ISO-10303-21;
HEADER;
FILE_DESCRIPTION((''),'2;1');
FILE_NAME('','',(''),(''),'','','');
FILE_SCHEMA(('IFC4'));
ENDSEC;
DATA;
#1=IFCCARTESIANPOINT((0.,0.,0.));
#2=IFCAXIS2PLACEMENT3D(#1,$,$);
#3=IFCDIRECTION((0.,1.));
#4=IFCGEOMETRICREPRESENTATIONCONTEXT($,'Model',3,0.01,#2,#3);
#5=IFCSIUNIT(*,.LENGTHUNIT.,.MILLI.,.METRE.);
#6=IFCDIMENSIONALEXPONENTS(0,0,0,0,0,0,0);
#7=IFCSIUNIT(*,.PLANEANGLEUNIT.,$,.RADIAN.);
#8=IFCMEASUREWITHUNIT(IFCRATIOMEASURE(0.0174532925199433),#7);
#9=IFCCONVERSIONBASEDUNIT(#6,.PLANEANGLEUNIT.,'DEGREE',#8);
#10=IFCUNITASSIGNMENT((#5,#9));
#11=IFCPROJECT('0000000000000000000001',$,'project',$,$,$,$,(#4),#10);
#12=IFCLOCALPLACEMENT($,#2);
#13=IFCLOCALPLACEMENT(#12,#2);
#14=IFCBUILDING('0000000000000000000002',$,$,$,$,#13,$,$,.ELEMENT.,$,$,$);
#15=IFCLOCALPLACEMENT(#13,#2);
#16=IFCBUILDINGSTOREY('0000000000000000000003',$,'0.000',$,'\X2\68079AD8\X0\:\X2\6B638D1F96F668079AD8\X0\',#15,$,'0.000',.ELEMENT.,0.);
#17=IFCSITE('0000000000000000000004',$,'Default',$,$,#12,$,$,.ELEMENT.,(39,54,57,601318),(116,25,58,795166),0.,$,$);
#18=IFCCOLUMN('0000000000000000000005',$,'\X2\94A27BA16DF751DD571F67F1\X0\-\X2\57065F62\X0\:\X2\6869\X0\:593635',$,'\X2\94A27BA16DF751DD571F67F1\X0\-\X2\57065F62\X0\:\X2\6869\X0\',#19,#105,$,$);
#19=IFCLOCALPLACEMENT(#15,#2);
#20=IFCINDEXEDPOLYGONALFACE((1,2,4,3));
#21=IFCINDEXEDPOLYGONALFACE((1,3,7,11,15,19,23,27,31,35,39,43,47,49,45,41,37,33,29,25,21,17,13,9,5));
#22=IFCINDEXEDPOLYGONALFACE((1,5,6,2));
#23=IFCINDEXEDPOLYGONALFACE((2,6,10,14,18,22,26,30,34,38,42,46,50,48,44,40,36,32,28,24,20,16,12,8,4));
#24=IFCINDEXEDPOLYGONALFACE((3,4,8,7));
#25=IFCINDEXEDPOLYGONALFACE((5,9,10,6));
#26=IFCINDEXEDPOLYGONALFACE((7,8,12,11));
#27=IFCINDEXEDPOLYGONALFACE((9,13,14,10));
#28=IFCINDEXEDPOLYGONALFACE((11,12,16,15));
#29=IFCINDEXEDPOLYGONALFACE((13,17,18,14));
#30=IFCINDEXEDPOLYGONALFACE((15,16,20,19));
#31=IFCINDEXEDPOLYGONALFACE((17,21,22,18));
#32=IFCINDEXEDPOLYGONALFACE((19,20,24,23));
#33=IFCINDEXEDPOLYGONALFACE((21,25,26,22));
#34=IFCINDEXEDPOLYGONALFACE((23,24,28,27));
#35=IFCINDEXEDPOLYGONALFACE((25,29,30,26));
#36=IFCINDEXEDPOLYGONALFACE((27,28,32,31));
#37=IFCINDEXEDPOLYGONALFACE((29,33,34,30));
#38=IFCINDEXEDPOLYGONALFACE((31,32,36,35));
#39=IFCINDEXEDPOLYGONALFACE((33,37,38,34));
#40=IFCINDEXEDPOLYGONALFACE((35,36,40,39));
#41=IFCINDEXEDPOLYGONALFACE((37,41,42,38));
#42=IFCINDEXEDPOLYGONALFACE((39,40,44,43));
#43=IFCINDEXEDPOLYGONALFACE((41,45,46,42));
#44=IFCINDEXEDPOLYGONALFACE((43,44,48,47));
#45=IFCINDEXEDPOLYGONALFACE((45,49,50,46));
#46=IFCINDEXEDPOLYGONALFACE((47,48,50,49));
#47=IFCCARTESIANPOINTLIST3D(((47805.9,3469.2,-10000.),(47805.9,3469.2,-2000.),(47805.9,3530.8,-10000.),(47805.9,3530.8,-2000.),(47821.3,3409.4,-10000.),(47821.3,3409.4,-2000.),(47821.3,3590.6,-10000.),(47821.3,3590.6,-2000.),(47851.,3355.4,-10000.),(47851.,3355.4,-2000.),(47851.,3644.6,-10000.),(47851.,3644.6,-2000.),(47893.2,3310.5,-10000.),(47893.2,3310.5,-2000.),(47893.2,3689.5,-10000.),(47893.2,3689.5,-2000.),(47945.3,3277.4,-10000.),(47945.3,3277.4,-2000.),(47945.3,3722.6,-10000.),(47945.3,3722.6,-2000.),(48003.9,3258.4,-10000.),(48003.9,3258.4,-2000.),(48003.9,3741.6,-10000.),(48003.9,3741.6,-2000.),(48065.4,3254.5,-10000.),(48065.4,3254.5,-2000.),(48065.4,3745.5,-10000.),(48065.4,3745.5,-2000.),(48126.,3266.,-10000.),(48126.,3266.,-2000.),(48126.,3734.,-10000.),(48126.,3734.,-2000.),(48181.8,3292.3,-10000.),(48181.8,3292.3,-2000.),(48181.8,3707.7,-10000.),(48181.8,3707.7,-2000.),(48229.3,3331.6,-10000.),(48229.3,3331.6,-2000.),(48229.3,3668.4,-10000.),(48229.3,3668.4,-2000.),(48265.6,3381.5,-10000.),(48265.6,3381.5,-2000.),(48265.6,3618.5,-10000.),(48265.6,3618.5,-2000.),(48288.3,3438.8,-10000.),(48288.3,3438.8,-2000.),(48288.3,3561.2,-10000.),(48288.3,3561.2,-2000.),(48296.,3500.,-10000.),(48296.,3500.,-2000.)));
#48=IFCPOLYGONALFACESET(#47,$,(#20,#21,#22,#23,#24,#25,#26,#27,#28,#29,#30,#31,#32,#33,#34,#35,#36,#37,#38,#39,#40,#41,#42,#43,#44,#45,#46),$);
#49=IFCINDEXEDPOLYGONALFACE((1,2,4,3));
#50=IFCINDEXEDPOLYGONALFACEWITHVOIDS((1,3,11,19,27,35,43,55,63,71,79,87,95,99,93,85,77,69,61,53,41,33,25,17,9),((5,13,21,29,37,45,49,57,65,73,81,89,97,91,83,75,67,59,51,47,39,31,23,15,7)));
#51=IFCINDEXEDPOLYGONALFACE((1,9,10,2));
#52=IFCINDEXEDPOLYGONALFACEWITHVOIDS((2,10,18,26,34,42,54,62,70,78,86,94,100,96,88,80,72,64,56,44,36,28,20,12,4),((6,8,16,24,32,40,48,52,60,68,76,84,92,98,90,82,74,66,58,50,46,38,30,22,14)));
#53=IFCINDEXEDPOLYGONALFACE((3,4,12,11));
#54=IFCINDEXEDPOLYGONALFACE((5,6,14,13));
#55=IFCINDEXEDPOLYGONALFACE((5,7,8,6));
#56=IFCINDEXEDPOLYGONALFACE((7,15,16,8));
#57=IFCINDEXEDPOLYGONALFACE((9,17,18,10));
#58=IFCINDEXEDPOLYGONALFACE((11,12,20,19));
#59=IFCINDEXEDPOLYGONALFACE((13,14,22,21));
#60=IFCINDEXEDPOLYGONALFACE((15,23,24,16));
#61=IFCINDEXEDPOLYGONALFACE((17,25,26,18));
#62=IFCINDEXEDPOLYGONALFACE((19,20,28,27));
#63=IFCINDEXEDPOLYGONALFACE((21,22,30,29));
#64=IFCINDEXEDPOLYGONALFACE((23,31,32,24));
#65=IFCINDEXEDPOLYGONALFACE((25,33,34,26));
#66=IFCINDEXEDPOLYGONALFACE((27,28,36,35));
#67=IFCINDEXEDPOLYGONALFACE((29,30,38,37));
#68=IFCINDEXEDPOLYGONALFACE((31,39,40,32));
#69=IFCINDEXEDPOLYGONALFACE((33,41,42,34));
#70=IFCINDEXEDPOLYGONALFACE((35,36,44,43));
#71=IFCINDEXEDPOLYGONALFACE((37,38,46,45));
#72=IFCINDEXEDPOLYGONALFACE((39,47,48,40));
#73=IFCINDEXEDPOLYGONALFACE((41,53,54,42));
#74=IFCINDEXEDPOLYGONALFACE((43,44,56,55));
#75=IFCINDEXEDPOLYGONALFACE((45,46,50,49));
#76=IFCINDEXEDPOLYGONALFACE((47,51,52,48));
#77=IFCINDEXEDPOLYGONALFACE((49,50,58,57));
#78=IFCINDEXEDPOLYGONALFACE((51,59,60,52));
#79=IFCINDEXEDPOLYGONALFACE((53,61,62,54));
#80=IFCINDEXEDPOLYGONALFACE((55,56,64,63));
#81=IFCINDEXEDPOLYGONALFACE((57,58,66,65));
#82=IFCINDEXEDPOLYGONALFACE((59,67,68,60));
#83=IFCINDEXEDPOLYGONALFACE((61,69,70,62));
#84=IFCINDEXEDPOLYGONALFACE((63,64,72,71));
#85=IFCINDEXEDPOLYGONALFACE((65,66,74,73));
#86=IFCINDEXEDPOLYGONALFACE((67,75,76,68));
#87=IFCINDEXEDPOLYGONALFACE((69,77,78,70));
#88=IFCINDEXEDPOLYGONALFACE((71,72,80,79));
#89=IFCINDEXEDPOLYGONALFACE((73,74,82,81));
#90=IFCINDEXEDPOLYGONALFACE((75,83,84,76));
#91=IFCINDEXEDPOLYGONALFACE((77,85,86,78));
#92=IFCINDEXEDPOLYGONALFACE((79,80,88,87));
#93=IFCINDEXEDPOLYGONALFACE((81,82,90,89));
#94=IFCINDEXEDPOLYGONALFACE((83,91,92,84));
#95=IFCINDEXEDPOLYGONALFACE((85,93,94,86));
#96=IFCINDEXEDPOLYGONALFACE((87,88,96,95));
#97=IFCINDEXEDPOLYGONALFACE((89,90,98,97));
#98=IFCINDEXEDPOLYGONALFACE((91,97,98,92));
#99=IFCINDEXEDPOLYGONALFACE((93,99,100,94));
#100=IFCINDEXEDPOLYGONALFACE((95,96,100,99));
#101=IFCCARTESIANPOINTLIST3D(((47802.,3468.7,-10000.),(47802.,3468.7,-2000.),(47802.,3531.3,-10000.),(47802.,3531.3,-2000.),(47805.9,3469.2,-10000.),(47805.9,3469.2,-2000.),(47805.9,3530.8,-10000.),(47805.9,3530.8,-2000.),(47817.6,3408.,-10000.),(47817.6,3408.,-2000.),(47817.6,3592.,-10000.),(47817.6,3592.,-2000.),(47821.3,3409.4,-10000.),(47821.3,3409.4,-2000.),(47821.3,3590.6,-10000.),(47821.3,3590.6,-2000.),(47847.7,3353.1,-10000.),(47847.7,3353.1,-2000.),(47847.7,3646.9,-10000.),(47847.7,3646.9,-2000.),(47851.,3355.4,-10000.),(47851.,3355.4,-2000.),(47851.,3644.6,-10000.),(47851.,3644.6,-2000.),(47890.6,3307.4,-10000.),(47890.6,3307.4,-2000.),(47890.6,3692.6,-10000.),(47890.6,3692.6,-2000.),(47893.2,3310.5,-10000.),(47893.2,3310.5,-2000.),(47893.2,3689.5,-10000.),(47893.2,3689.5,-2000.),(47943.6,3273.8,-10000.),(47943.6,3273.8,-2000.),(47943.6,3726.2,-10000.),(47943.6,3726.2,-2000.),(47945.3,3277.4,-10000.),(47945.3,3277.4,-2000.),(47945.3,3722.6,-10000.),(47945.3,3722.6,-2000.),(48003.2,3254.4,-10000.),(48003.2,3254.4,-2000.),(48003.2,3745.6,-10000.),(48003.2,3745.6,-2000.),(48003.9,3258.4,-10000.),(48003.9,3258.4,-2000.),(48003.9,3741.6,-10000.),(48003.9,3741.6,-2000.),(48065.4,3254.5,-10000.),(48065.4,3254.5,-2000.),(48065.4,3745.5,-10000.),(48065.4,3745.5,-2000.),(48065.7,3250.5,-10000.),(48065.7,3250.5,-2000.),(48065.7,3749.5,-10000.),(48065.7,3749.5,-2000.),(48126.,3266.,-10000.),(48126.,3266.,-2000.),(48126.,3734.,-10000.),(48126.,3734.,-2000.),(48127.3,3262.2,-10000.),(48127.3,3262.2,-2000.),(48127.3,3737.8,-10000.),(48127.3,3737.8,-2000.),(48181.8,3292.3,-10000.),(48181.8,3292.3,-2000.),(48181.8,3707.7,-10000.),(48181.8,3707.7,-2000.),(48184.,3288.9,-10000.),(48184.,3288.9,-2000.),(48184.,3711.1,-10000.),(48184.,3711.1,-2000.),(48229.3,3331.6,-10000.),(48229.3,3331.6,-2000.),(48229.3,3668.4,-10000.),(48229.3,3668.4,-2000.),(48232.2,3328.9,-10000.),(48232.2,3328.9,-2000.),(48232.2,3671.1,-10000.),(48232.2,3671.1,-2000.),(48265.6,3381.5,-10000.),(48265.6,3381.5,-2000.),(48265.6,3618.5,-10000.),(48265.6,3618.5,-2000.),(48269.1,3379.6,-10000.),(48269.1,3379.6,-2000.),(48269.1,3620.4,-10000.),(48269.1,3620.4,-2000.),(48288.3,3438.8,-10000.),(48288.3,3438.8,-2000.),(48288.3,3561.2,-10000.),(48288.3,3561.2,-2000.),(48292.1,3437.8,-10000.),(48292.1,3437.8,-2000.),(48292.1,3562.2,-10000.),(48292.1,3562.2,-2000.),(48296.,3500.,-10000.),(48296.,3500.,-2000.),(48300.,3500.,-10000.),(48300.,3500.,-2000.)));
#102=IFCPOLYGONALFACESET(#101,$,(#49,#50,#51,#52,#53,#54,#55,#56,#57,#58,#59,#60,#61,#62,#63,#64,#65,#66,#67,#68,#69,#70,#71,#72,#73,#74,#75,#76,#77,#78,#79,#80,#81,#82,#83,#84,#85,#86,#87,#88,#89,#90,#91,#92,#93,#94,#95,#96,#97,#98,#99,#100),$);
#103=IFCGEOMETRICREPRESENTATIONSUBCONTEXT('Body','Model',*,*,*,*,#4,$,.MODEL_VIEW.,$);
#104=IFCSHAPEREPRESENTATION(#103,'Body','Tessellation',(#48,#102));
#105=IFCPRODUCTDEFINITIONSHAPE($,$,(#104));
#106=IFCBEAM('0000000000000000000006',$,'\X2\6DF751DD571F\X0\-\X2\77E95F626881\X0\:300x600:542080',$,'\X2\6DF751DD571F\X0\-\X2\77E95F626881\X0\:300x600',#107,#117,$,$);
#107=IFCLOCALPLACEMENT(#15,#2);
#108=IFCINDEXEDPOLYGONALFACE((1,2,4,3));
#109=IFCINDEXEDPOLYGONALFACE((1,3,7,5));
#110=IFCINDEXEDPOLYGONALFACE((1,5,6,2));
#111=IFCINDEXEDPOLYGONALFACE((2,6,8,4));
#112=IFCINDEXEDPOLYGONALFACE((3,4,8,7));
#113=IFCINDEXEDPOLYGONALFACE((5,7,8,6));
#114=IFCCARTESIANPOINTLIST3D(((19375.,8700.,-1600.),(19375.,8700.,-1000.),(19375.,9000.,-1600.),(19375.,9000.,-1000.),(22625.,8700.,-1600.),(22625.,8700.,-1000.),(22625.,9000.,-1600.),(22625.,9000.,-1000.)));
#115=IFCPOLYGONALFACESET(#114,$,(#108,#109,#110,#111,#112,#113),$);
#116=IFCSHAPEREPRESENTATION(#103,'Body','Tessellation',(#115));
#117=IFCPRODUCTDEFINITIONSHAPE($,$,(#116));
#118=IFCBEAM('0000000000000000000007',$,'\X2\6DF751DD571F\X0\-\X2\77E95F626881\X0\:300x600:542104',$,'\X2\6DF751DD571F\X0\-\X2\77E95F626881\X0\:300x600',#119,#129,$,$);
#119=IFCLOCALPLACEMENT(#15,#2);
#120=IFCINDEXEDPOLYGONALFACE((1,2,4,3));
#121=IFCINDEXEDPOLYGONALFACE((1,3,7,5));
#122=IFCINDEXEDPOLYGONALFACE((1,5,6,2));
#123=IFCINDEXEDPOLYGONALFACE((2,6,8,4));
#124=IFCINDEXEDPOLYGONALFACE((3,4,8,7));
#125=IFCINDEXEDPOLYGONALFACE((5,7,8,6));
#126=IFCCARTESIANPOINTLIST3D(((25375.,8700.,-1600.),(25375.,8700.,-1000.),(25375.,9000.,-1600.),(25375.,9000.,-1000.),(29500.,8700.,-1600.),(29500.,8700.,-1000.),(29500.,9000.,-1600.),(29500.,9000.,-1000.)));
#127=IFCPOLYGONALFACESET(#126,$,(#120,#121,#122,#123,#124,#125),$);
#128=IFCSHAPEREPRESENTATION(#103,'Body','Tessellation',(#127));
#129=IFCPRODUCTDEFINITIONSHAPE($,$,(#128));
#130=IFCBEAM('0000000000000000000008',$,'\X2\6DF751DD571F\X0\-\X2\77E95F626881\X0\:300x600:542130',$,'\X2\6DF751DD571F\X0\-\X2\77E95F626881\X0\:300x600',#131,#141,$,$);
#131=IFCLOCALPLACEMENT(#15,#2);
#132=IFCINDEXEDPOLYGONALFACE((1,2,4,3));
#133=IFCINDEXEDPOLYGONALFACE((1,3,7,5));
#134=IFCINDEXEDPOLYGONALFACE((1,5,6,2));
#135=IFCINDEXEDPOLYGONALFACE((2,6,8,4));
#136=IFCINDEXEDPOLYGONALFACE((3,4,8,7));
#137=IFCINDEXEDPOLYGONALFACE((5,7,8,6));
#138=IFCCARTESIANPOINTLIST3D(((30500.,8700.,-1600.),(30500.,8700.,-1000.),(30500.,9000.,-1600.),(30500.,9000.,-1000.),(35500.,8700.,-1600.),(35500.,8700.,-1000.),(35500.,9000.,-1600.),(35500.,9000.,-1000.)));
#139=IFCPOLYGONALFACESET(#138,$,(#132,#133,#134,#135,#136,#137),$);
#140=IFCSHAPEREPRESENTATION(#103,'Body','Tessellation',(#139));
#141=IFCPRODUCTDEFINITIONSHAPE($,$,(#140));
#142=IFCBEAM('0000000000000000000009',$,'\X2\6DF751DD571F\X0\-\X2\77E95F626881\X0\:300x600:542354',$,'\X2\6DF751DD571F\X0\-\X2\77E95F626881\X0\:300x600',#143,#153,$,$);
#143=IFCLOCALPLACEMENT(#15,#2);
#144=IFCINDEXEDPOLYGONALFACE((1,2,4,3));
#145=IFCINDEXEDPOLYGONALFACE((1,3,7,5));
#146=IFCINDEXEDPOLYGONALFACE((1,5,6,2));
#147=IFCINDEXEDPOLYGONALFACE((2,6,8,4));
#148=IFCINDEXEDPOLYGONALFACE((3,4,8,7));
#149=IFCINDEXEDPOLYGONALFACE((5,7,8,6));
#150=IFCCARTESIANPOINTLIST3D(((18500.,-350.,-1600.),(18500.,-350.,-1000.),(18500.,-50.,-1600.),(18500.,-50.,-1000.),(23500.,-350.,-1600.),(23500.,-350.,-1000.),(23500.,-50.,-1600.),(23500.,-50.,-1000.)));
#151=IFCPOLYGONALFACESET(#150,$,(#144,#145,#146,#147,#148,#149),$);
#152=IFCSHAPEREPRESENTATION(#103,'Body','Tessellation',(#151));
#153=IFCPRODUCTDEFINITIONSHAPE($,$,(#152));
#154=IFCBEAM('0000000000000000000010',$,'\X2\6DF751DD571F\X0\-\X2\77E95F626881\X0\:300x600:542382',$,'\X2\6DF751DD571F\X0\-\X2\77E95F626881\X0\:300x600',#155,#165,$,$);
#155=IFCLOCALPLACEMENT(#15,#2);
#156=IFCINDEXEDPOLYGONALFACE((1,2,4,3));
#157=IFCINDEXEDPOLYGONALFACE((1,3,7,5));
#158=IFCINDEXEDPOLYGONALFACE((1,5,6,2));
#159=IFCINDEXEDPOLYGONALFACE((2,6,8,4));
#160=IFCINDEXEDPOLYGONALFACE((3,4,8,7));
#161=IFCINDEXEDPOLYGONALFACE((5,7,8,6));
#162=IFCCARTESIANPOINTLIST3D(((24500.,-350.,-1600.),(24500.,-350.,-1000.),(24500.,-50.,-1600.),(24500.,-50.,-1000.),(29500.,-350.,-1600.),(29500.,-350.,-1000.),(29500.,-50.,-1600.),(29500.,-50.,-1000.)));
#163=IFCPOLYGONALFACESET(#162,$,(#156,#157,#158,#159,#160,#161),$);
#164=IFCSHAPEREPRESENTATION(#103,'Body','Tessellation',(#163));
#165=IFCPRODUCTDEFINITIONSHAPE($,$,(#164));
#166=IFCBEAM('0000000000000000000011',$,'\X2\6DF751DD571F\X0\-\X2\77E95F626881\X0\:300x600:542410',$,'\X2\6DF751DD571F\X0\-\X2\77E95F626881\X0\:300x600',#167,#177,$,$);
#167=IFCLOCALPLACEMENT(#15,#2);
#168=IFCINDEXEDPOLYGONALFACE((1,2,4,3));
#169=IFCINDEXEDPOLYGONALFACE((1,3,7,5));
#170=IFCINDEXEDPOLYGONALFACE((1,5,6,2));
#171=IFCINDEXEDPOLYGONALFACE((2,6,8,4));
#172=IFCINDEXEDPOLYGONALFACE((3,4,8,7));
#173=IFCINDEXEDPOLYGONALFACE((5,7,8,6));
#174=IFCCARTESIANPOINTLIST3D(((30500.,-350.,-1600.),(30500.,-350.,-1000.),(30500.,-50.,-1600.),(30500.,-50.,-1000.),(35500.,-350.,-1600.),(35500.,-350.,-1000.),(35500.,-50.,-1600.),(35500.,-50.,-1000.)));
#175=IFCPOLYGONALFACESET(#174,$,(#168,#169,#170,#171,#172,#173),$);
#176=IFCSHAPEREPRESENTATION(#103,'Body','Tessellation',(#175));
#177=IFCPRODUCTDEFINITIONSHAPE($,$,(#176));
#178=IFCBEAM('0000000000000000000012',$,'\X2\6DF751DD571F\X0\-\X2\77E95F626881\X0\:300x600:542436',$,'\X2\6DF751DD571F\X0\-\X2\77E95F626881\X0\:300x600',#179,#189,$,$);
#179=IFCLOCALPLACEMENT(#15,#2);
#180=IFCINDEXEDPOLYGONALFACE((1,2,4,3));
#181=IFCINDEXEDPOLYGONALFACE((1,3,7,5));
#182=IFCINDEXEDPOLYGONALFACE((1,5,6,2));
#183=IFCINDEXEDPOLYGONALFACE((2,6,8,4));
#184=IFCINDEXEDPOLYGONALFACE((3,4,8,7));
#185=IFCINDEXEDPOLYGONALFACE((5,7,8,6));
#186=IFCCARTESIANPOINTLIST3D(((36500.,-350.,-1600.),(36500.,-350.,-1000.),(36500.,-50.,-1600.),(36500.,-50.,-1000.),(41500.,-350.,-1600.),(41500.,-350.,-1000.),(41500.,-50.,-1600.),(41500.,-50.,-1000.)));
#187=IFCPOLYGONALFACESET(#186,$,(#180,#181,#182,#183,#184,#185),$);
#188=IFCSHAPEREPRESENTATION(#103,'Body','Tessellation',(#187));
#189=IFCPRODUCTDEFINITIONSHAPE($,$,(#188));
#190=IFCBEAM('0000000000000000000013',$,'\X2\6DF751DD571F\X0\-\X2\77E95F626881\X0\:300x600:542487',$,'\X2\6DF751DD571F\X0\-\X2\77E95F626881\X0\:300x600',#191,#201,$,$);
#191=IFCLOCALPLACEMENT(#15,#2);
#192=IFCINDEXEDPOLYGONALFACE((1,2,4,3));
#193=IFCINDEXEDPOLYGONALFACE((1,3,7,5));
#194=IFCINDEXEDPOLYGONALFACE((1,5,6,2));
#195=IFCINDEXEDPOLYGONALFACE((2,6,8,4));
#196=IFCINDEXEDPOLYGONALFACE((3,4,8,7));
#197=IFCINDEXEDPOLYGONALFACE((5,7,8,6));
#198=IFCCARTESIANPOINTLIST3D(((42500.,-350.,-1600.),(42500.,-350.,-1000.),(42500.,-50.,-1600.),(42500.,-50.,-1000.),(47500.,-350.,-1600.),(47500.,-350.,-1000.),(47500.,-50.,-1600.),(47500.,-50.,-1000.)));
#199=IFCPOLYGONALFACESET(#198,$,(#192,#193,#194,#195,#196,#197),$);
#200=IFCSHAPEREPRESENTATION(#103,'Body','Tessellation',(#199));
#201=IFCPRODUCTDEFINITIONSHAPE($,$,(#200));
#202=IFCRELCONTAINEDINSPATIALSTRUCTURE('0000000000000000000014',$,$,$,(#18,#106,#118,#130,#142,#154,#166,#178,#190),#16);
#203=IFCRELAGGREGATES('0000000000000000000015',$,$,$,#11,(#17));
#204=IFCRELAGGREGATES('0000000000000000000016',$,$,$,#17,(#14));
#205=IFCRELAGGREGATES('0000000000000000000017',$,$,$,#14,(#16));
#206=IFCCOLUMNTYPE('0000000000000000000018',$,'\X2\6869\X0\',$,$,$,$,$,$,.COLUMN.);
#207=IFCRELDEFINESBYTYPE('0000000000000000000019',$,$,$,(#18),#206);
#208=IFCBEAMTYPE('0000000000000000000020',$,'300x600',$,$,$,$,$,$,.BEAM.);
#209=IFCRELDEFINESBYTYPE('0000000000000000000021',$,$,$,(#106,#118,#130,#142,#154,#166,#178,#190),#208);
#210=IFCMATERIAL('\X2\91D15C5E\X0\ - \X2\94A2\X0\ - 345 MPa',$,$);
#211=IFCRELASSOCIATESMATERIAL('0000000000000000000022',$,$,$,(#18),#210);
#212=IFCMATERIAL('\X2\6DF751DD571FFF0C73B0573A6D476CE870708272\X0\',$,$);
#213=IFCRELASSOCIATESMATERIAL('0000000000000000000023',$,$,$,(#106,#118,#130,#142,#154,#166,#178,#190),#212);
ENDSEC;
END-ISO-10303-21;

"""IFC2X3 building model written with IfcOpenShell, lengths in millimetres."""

from ifc_helpers import new_model, entity, si_unit, converted_unit, direction, frame, frame_2d, origin, place, context, subcontext, project, spatial, rectangle, circle, hollow_circle, extrude, source, transform, mapped, material, type_object, type_shapes, element, save


model = new_model("IFC2X3")

# Units and contexts
model_context = context("Model", 3, precision=0.01, world=origin(), true_north=direction((0.0, 1.0)))
body_context = subcontext(model_context, "Body", "Model", "MODEL_VIEW")
ifc_project = project(units=[si_unit("LENGTHUNIT", "METRE", prefix="MILLI"), converted_unit("PLANEANGLEUNIT", "DEGREE", entity("IfcRatioMeasure", 0.0174532925199433), si_unit("PLANEANGLEUNIT", "RADIAN"), dimensions=[0, 0, 0, 0, 0, 0, 0])], contexts=[model_context])

# Site, building, storey
site_placement = place(None, origin())
site = spatial("IfcSite", under=ifc_project, at=site_placement, Name="Default", CompositionType="ELEMENT", RefLatitude=(39, 54, 57, 601318), RefLongitude=(116, 25, 58, 795166), RefElevation=0.0)
building_placement = place(site_placement, origin())
building = spatial("IfcBuilding", under=site, at=building_placement, CompositionType="ELEMENT")
storey_placement = place(building_placement, origin())
storey = spatial("IfcBuildingStorey", under=building, at=storey_placement, Name="0.000", ObjectType="标高:正负零标高", LongName="0.000", CompositionType="ELEMENT", Elevation=0.0)

# Column
ifc_material_1 = material(Name="金属 - 钢 - 345 MPa")
column_type = type_object("IfcColumnType", Name="桩", PredefinedType="COLUMN")
shared_shape = source(origin(), body_context, "Body", "SweptSolid", [
    extrude(circle(Radius=246.0, at=frame_2d((0.0, 0.0), x_axis=(1.0, 0.0))), frame((0.0, 0.0, -10000.0)), (0.0, 0.0, 1.0), 8000.0),
    extrude(hollow_circle(Radius=250.0, WallThickness=4.0, at=frame_2d((0.0, 0.0), x_axis=(1.0, 0.0))), frame((0.0, 0.0, -10000.0)), (0.0, 0.0, 1.0), 8000.0),
])
type_shapes(column_type, [shared_shape])
for number, where, name in (
    (1, (48050.0, 3500.0, 0.0), "钢管混凝土柱-圆形:桩:593635"),
):
    element("IfcColumn", number, at=place(storey_placement, frame(where)), inside=storey, type_object=column_type, material=ifc_material_1, Name=name, ObjectType="钢管混凝土柱-圆形:桩", context=body_context, shape_type="MappedRepresentation", body=[
        mapped(shared_shape, transform((0.0, 0.0, 0.0), scale=1.0)),
    ])

# Beams
ifc_material_2 = material(Name="混凝土，现场浇注灰色")
beam_type = type_object("IfcBeamType", Name="300x600", PredefinedType="BEAM")
beam_1_placement = place(storey_placement, frame((19375.0, 9000.0, 0.0)))
element("IfcBeam", 2, at=beam_1_placement, inside=storey, type_object=beam_type, material=ifc_material_2, Name="混凝土-矩形梁:300x600:542080", ObjectType="混凝土-矩形梁:300x600", context=body_context, shape_type="SweptSolid", body=[
    extrude(rectangle(XDim=600.0, YDim=300.0, at=frame_2d((0.0, 0.0), x_axis=(1.0, 0.0))), frame((0.0, -150.0, -1300.0), z_axis=(1.0, 0.0, 0.0), x_axis=(0.0, 0.0, -1.0)), (0.0, 0.0, 1.0), 3250.0),
])
beam_2_placement = place(storey_placement, frame((25375.0, 9000.0, 0.0)))
element("IfcBeam", 3, at=beam_2_placement, inside=storey, type_object=beam_type, material=ifc_material_2, Name="混凝土-矩形梁:300x600:542104", ObjectType="混凝土-矩形梁:300x600", context=body_context, shape_type="SweptSolid", body=[
    extrude(rectangle(XDim=600.0, YDim=300.0, at=frame_2d((0.0, 0.0), x_axis=(1.0, 0.0))), frame((0.0, -150.0, -1300.0), z_axis=(1.0, 0.0, 0.0), x_axis=(0.0, 0.0, -1.0)), (0.0, 0.0, 1.0), 4125.0),
])
beam_3_placement = place(storey_placement, frame((30500.0, 9000.0, 0.0)))
element("IfcBeam", 4, at=beam_3_placement, inside=storey, type_object=beam_type, material=ifc_material_2, Name="混凝土-矩形梁:300x600:542130", ObjectType="混凝土-矩形梁:300x600", context=body_context, shape_type="SweptSolid", body=[
    extrude(rectangle(XDim=600.0, YDim=300.0, at=frame_2d((0.0, 0.0), x_axis=(1.0, 0.0))), frame((0.0, -150.0, -1300.0), z_axis=(1.0, 0.0, 0.0), x_axis=(0.0, 0.0, -1.0)), (0.0, 0.0, 1.0), 5000.0),
])
beam_4_placement = place(storey_placement, frame((18500.0, -50.0, 0.0)))
element("IfcBeam", 5, at=beam_4_placement, inside=storey, type_object=beam_type, material=ifc_material_2, Name="混凝土-矩形梁:300x600:542354", ObjectType="混凝土-矩形梁:300x600", context=body_context, shape_type="SweptSolid", body=[
    extrude(rectangle(XDim=600.0, YDim=300.0, at=frame_2d((0.0, 0.0), x_axis=(1.0, 0.0))), frame((0.0, -150.0, -1300.0), z_axis=(1.0, 0.0, 0.0), x_axis=(0.0, 0.0, -1.0)), (0.0, 0.0, 1.0), 5000.0),
])
beam_5_placement = place(storey_placement, frame((24500.0, -50.0, 0.0)))
element("IfcBeam", 6, at=beam_5_placement, inside=storey, type_object=beam_type, material=ifc_material_2, Name="混凝土-矩形梁:300x600:542382", ObjectType="混凝土-矩形梁:300x600", context=body_context, shape_type="SweptSolid", body=[
    extrude(rectangle(XDim=600.0, YDim=300.0, at=frame_2d((0.0, 0.0), x_axis=(1.0, 0.0))), frame((0.0, -150.0, -1300.0), z_axis=(1.0, 0.0, 0.0), x_axis=(0.0, 0.0, -1.0)), (0.0, 0.0, 1.0), 5000.0),
])
beam_6_placement = place(storey_placement, frame((30500.0, -50.0, 0.0)))
element("IfcBeam", 7, at=beam_6_placement, inside=storey, type_object=beam_type, material=ifc_material_2, Name="混凝土-矩形梁:300x600:542410", ObjectType="混凝土-矩形梁:300x600", context=body_context, shape_type="SweptSolid", body=[
    extrude(rectangle(XDim=600.0, YDim=300.0, at=frame_2d((0.0, 0.0), x_axis=(1.0, 0.0))), frame((0.0, -150.0, -1300.0), z_axis=(1.0, 0.0, 0.0), x_axis=(0.0, 0.0, -1.0)), (0.0, 0.0, 1.0), 5000.0),
])
beam_7_placement = place(storey_placement, frame((36500.0, -50.0, 0.0)))
element("IfcBeam", 8, at=beam_7_placement, inside=storey, type_object=beam_type, material=ifc_material_2, Name="混凝土-矩形梁:300x600:542436", ObjectType="混凝土-矩形梁:300x600", context=body_context, shape_type="SweptSolid", body=[
    extrude(rectangle(XDim=600.0, YDim=300.0, at=frame_2d((0.0, 0.0), x_axis=(1.0, 0.0))), frame((0.0, -150.0, -1300.0), z_axis=(1.0, 0.0, 0.0), x_axis=(0.0, 0.0, -1.0)), (0.0, 0.0, 1.0), 5000.0),
])
beam_8_placement = place(storey_placement, frame((42500.0, -50.0, 0.0)))
element("IfcBeam", 9, at=beam_8_placement, inside=storey, type_object=beam_type, material=ifc_material_2, Name="混凝土-矩形梁:300x600:542487", ObjectType="混凝土-矩形梁:300x600", context=body_context, shape_type="SweptSolid", body=[
    extrude(rectangle(XDim=600.0, YDim=300.0, at=frame_2d((0.0, 0.0), x_axis=(1.0, 0.0))), frame((0.0, -150.0, -1300.0), z_axis=(1.0, 0.0, 0.0), x_axis=(0.0, 0.0, -1.0)), (0.0, 0.0, 1.0), 5000.0),
])

save(model, "model.ifc")
